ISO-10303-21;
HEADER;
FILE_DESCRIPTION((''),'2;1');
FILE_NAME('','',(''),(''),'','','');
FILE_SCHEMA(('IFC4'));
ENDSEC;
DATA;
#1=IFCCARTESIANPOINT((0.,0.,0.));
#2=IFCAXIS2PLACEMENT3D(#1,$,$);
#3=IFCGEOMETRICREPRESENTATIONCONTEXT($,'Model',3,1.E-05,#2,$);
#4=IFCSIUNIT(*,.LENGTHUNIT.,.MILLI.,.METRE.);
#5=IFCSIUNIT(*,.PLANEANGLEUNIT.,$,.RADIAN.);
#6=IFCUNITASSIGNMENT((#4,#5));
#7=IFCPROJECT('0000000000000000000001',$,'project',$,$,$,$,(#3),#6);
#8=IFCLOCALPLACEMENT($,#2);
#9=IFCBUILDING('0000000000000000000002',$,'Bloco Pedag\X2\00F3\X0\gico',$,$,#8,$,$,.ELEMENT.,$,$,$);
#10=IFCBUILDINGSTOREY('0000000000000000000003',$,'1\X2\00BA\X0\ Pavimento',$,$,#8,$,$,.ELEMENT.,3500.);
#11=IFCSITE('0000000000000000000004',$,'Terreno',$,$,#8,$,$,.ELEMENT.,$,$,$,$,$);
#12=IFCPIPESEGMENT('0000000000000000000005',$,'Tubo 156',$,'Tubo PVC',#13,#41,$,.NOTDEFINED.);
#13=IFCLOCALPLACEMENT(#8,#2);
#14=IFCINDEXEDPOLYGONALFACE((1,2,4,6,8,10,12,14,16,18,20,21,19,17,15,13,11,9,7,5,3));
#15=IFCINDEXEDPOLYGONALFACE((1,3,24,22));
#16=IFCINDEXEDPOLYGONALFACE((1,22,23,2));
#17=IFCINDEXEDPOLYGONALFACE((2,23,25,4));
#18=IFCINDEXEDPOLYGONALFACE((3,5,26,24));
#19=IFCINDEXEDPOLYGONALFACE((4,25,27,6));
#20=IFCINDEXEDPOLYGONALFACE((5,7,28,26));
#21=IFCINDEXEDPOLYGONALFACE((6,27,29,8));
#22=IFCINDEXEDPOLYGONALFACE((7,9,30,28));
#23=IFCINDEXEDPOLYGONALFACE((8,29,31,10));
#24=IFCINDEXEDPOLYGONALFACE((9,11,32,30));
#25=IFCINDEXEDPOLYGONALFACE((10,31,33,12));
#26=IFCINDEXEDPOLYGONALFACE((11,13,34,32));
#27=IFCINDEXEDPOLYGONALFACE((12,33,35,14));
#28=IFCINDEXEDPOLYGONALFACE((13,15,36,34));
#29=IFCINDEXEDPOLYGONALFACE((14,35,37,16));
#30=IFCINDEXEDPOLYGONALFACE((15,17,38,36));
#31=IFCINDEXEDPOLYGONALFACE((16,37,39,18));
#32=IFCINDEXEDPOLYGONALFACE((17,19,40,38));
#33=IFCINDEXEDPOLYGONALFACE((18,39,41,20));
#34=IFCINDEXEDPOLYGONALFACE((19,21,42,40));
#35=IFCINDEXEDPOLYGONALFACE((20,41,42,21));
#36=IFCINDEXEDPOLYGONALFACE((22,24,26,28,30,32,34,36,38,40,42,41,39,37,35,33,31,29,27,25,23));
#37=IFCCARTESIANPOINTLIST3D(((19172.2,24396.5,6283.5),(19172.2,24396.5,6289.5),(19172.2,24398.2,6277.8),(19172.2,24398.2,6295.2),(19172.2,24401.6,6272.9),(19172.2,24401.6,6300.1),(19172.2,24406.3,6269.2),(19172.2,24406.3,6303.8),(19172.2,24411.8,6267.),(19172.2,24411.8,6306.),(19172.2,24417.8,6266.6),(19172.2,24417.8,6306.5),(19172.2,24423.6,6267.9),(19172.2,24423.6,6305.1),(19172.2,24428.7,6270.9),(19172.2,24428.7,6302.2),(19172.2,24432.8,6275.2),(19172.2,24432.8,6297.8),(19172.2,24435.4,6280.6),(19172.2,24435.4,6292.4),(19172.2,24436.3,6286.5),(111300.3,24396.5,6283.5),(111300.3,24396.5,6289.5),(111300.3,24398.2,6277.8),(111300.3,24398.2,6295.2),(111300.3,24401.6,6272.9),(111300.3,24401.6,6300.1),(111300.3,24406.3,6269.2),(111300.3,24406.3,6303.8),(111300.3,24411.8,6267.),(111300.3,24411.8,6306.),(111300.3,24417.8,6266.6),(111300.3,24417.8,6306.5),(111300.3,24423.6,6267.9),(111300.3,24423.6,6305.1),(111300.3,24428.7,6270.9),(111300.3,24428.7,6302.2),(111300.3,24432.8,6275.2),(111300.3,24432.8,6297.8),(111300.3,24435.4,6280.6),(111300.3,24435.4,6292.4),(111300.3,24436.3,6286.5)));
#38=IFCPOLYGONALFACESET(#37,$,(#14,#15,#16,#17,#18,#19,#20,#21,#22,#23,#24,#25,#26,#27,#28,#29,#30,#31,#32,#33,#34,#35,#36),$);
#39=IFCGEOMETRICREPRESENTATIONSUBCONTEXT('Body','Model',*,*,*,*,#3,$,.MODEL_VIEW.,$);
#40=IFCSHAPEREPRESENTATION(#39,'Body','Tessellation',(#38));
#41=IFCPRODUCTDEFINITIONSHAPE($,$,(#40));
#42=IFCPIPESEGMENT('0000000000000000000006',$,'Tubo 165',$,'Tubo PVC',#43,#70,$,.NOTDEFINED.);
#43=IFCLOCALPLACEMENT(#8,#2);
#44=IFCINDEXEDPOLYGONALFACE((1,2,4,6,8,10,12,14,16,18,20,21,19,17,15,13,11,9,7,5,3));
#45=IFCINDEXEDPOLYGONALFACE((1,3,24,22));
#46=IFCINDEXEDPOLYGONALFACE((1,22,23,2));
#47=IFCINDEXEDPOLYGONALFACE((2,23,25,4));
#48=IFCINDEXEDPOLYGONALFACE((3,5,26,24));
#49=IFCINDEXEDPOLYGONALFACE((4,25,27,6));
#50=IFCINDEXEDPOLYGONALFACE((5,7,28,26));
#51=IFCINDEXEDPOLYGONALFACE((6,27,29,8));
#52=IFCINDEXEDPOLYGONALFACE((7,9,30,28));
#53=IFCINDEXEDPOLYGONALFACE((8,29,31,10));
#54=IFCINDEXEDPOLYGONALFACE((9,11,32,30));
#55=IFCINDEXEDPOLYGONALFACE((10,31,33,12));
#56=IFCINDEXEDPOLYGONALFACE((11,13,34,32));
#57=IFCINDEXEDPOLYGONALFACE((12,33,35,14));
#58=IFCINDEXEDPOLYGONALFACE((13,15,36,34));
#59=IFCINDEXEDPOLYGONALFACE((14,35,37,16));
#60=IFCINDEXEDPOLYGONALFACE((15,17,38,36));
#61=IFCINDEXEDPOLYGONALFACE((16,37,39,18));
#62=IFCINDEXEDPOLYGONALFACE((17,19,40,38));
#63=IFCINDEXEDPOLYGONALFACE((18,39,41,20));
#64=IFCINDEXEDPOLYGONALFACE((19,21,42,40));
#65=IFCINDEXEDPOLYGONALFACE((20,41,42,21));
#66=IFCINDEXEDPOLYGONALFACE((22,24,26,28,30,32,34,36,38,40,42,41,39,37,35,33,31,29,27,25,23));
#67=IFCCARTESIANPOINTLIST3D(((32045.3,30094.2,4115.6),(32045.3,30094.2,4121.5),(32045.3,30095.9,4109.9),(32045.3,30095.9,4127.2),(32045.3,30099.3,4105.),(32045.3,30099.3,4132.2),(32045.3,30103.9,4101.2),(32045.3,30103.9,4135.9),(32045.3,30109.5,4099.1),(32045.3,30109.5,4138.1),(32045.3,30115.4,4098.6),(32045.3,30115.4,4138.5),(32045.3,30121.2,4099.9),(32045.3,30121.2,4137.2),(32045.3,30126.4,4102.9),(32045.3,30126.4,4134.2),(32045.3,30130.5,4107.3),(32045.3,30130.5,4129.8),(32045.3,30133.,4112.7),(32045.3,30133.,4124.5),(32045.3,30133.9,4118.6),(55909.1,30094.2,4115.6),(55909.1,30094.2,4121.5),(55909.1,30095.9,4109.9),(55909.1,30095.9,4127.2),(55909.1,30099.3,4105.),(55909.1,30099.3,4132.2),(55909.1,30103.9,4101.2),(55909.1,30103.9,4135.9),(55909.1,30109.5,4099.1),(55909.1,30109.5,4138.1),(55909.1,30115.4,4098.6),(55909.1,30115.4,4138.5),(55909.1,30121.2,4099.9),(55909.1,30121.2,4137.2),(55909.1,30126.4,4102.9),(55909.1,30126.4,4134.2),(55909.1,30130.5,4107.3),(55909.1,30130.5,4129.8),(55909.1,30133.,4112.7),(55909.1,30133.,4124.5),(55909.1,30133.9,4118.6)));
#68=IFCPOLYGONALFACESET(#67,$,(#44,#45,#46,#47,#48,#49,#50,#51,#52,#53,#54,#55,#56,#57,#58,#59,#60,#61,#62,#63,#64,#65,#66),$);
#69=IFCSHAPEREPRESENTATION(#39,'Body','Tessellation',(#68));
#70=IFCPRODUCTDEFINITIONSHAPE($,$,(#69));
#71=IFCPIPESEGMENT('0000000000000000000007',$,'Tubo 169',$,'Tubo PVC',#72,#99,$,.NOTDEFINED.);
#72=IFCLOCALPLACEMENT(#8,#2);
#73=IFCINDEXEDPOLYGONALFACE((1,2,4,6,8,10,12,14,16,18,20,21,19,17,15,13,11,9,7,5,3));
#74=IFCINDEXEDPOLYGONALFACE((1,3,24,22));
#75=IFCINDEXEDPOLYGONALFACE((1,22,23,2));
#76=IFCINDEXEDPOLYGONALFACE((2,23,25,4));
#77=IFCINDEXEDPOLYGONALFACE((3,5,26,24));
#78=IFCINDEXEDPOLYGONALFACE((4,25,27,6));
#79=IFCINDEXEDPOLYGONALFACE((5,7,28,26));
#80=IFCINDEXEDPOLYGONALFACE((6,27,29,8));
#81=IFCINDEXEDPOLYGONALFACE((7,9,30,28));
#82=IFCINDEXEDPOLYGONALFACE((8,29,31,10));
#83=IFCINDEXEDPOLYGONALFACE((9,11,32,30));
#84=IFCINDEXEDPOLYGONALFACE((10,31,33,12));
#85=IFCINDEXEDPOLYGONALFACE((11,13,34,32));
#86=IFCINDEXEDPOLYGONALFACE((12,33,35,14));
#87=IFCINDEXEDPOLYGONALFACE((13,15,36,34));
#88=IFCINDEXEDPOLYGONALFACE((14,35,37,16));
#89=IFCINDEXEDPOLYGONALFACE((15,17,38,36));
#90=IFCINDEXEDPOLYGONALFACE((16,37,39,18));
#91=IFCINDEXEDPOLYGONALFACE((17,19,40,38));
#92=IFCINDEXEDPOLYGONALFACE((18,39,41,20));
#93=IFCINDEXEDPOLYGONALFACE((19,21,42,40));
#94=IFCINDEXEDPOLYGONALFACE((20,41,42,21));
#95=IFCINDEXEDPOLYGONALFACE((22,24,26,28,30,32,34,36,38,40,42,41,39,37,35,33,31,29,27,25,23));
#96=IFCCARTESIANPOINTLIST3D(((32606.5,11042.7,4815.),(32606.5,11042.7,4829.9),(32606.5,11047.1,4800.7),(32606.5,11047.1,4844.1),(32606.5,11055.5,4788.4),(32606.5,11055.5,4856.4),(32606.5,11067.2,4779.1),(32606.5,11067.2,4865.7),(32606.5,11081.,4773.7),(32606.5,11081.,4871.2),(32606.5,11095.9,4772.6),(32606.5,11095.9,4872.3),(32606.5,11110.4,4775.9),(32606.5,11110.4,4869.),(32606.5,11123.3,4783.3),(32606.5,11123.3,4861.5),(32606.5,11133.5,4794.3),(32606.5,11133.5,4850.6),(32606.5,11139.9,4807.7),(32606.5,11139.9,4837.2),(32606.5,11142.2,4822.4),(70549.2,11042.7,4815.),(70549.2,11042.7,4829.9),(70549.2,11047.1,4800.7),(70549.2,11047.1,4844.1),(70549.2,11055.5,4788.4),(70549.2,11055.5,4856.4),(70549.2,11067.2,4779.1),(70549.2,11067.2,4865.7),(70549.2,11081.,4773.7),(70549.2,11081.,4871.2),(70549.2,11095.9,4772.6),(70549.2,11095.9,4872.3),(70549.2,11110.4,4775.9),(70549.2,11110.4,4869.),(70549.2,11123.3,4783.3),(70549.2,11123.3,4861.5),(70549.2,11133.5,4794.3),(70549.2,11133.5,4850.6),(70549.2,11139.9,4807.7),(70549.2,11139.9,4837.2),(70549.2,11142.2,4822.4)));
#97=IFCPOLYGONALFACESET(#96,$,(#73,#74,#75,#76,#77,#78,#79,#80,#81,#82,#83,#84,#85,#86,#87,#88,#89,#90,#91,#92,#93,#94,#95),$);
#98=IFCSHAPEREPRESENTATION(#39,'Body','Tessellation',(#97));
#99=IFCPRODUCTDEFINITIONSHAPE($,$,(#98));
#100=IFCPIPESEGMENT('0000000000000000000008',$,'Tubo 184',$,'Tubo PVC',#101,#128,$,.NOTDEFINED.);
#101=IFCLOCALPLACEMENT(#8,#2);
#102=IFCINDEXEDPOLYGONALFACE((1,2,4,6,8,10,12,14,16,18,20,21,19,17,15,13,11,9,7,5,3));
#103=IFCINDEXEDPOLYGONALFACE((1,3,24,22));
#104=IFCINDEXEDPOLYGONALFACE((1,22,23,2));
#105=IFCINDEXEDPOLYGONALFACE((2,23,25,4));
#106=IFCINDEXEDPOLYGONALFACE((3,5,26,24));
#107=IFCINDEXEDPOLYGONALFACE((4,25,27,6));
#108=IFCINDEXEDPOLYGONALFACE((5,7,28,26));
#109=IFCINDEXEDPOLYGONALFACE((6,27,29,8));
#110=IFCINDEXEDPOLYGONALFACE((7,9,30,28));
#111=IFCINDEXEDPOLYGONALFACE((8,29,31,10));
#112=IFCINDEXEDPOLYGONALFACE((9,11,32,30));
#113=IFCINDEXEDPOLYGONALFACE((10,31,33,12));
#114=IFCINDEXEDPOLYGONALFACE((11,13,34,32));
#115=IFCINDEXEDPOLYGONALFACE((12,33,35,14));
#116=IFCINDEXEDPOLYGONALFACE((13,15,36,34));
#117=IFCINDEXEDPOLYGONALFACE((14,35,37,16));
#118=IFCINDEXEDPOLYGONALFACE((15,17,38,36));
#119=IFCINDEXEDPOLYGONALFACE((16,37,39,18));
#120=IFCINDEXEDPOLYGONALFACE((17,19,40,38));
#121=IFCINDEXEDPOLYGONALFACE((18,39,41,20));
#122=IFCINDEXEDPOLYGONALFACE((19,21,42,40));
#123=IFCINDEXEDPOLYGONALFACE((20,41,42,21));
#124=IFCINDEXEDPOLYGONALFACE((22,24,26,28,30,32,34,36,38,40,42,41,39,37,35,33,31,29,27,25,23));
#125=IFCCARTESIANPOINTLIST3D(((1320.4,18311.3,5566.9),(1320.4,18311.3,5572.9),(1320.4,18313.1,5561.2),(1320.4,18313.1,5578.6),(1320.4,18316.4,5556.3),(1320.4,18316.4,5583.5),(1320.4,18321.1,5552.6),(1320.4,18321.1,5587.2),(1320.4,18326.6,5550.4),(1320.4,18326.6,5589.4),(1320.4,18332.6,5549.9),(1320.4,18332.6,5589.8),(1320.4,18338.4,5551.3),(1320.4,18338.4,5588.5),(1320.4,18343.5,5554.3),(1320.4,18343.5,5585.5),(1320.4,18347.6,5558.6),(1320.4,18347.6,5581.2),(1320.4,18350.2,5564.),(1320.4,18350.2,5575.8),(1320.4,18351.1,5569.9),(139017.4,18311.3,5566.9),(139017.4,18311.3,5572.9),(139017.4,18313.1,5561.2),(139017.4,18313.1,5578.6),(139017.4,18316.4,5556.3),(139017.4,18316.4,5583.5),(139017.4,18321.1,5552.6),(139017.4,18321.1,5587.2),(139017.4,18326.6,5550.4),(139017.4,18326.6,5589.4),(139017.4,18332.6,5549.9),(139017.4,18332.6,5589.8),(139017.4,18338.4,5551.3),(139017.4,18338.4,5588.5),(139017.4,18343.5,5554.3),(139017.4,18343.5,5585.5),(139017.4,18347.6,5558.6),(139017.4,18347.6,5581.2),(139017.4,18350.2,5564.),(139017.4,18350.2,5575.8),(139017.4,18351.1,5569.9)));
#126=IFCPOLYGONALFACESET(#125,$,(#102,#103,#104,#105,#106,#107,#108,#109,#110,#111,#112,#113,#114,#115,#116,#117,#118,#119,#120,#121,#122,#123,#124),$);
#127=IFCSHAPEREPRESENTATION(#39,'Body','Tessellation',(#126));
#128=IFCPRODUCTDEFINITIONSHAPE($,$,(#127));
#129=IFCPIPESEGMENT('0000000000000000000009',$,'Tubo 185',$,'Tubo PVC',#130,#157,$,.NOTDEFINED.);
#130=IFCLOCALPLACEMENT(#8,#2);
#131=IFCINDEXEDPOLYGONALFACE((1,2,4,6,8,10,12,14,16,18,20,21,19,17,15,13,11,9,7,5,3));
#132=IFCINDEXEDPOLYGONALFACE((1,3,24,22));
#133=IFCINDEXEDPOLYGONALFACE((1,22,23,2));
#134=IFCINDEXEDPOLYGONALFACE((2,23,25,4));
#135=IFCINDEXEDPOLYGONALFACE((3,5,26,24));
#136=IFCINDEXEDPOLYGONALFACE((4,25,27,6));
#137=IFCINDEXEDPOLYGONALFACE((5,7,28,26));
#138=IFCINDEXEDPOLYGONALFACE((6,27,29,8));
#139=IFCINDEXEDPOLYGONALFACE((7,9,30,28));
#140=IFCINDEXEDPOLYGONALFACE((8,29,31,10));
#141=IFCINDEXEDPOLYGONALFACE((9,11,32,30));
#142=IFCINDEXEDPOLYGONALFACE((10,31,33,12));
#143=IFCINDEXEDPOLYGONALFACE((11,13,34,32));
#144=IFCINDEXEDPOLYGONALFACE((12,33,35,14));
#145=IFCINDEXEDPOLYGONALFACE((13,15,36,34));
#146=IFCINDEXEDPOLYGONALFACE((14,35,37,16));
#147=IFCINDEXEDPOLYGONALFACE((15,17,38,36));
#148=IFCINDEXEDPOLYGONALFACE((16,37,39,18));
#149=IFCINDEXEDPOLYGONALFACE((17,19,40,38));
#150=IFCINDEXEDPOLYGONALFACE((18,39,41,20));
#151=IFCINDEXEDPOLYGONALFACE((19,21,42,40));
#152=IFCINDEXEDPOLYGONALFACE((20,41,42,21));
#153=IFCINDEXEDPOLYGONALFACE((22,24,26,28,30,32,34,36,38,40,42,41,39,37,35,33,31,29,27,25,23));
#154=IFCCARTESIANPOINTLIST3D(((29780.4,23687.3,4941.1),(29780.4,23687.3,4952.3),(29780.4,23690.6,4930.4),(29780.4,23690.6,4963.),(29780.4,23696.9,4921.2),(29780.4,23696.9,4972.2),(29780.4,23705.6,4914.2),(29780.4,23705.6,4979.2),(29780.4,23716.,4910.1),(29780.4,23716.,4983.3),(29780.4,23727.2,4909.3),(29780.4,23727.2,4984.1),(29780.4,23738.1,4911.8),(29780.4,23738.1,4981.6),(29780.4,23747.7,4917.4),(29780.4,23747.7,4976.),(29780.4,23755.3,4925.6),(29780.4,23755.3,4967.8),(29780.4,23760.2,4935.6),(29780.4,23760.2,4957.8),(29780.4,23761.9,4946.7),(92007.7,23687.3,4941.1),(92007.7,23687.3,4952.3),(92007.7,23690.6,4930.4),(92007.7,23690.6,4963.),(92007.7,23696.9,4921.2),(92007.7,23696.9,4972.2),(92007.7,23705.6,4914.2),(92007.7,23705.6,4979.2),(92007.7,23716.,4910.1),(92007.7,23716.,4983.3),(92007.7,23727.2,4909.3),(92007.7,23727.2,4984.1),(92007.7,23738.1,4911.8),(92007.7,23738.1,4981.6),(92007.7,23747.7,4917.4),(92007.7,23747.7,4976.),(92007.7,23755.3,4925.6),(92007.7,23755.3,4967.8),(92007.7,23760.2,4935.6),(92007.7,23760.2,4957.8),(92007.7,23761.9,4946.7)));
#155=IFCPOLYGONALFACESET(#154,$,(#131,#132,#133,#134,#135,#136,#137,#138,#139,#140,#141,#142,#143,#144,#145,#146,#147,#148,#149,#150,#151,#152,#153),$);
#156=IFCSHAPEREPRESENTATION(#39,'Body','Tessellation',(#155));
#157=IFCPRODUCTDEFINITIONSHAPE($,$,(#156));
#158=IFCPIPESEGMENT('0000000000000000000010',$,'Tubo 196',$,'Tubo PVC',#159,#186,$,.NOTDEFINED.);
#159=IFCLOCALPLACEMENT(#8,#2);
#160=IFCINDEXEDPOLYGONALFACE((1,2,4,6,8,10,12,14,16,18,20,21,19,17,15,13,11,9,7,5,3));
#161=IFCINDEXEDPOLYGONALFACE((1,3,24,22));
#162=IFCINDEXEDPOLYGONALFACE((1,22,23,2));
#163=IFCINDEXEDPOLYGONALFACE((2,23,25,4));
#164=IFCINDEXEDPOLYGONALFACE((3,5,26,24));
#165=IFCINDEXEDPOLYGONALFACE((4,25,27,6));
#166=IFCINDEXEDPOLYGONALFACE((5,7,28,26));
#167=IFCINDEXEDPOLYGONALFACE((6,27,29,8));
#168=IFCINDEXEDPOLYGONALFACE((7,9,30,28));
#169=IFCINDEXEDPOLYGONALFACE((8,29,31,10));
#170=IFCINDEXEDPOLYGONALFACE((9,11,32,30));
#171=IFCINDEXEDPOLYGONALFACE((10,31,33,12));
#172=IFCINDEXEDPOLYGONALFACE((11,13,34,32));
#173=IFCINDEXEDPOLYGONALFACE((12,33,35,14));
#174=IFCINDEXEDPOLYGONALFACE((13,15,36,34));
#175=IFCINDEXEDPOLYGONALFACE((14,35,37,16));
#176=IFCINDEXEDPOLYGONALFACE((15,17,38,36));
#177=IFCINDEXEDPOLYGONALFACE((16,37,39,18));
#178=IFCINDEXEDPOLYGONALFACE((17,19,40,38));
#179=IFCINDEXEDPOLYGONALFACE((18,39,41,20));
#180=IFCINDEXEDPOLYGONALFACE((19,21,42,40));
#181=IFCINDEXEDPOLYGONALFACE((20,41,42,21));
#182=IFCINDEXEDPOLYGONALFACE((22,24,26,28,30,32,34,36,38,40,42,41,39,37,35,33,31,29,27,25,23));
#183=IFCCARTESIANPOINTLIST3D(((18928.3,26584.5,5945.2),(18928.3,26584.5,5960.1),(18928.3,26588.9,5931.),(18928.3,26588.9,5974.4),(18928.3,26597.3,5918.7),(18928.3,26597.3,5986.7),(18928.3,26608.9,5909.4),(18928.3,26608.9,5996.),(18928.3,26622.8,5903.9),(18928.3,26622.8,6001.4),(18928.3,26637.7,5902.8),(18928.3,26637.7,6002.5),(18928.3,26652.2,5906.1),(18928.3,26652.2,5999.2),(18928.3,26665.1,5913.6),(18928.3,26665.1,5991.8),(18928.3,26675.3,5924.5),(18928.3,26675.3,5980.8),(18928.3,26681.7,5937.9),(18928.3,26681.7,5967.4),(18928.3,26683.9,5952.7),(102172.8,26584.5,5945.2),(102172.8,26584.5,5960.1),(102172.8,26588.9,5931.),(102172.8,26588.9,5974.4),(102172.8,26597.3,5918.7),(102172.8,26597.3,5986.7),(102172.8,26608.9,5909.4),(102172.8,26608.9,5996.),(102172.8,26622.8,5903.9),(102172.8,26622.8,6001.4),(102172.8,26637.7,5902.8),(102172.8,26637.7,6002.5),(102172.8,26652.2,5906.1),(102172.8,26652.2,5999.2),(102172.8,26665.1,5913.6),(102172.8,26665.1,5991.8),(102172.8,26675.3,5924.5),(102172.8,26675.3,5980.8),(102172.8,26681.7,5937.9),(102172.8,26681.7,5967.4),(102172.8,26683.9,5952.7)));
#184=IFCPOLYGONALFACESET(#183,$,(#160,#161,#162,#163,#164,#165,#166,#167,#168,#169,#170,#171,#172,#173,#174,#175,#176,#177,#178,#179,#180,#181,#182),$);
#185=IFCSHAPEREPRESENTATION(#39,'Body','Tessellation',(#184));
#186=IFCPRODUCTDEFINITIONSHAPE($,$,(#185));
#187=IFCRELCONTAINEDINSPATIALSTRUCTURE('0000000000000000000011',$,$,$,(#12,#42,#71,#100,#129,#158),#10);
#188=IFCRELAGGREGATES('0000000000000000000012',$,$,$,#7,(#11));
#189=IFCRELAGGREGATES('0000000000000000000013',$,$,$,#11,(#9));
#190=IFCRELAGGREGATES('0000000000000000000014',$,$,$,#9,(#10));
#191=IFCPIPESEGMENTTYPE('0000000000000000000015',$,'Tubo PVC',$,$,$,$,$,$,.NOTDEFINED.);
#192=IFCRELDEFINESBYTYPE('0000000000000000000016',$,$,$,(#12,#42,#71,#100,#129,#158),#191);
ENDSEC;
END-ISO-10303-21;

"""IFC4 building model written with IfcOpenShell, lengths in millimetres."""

from ifc_helpers import new_model, si_unit, frame, origin, origin_2d, place, context, subcontext, project, spatial, circle, extrude, type_object, element, save


model = new_model("IFC4")

# Units and contexts
model_context = context("Model", 3, precision=1e-05, world=origin())
body_context = subcontext(model_context, "Body", "Model", "MODEL_VIEW")
ifc_project = project(units=[si_unit("LENGTHUNIT", "METRE", prefix="MILLI"), si_unit("PLANEANGLEUNIT", "RADIAN")], contexts=[model_context])

# Site, building, storey
placement = place(None, origin())
site = spatial("IfcSite", under=ifc_project, at=placement, Name="Terreno", CompositionType="ELEMENT")
building = spatial("IfcBuilding", under=site, at=placement, Name="Bloco Pedagógico", CompositionType="ELEMENT")
storey = spatial("IfcBuildingStorey", under=building, at=placement, Name="1º Pavimento", CompositionType="ELEMENT", Elevation=3500.0)

# Pipe segments
pipe_segment_type = type_object("IfcPipeSegmentType", Name="Tubo PVC", PredefinedType="NOTDEFINED")
pipe_segment_1_placement = place(None, frame((19172.2, 24416.3, 6286.5), z_axis=(1.0, 0.0, 0.0), x_axis=(0.0, 1.0, 0.0)))
element("IfcPipeSegment", 1, at=pipe_segment_1_placement, inside=storey, type_object=pipe_segment_type, Name="Tubo 156", ObjectType="Tubo PVC", PredefinedType="NOTDEFINED", context=body_context, shape_type="SweptSolid", body=[
    extrude(circle(Radius=20.0, at=origin_2d()), None, (0.0, 0.0, 1.0), 92128.2),
])
pipe_segment_2_placement = place(None, frame((32045.3, 30113.9, 4118.6), z_axis=(1.0, 0.0, 0.0), x_axis=(0.0, 1.0, 0.0)))
element("IfcPipeSegment", 2, at=pipe_segment_2_placement, inside=storey, type_object=pipe_segment_type, Name="Tubo 165", ObjectType="Tubo PVC", PredefinedType="NOTDEFINED", context=body_context, shape_type="SweptSolid", body=[
    extrude(circle(Radius=20.0, at=origin_2d()), None, (0.0, 0.0, 1.0), 23863.7),
])
pipe_segment_3_placement = place(None, frame((32606.5, 11092.2, 4822.4), z_axis=(1.0, 0.0, 0.0), x_axis=(0.0, 1.0, 0.0)))
element("IfcPipeSegment", 3, at=pipe_segment_3_placement, inside=storey, type_object=pipe_segment_type, Name="Tubo 169", ObjectType="Tubo PVC", PredefinedType="NOTDEFINED", context=body_context, shape_type="SweptSolid", body=[
    extrude(circle(Radius=50.0, at=origin_2d()), None, (0.0, 0.0, 1.0), 37942.7),
])
pipe_segment_4_placement = place(None, frame((1320.4, 18331.1, 5569.9), z_axis=(1.0, 0.0, 0.0), x_axis=(0.0, 1.0, 0.0)))
element("IfcPipeSegment", 4, at=pipe_segment_4_placement, inside=storey, type_object=pipe_segment_type, Name="Tubo 184", ObjectType="Tubo PVC", PredefinedType="NOTDEFINED", context=body_context, shape_type="SweptSolid", body=[
    extrude(circle(Radius=20.0, at=origin_2d()), None, (0.0, 0.0, 1.0), 137696.9),
])
pipe_segment_5_placement = place(None, frame((29780.4, 23724.4, 4946.7), z_axis=(1.0, 0.0, 0.0), x_axis=(0.0, 1.0, 0.0)))
element("IfcPipeSegment", 5, at=pipe_segment_5_placement, inside=storey, type_object=pipe_segment_type, Name="Tubo 185", ObjectType="Tubo PVC", PredefinedType="NOTDEFINED", context=body_context, shape_type="SweptSolid", body=[
    extrude(circle(Radius=37.5, at=origin_2d()), None, (0.0, 0.0, 1.0), 62227.4),
])
pipe_segment_6_placement = place(None, frame((18928.3, 26633.9, 5952.7), z_axis=(1.0, 0.0, 0.0), x_axis=(0.0, 1.0, 0.0)))
element("IfcPipeSegment", 6, at=pipe_segment_6_placement, inside=storey, type_object=pipe_segment_type, Name="Tubo 196", ObjectType="Tubo PVC", PredefinedType="NOTDEFINED", context=body_context, shape_type="SweptSolid", body=[
    extrude(circle(Radius=50.0, at=origin_2d()), None, (0.0, 0.0, 1.0), 83244.5),
])

save(model, "model.ifc")
